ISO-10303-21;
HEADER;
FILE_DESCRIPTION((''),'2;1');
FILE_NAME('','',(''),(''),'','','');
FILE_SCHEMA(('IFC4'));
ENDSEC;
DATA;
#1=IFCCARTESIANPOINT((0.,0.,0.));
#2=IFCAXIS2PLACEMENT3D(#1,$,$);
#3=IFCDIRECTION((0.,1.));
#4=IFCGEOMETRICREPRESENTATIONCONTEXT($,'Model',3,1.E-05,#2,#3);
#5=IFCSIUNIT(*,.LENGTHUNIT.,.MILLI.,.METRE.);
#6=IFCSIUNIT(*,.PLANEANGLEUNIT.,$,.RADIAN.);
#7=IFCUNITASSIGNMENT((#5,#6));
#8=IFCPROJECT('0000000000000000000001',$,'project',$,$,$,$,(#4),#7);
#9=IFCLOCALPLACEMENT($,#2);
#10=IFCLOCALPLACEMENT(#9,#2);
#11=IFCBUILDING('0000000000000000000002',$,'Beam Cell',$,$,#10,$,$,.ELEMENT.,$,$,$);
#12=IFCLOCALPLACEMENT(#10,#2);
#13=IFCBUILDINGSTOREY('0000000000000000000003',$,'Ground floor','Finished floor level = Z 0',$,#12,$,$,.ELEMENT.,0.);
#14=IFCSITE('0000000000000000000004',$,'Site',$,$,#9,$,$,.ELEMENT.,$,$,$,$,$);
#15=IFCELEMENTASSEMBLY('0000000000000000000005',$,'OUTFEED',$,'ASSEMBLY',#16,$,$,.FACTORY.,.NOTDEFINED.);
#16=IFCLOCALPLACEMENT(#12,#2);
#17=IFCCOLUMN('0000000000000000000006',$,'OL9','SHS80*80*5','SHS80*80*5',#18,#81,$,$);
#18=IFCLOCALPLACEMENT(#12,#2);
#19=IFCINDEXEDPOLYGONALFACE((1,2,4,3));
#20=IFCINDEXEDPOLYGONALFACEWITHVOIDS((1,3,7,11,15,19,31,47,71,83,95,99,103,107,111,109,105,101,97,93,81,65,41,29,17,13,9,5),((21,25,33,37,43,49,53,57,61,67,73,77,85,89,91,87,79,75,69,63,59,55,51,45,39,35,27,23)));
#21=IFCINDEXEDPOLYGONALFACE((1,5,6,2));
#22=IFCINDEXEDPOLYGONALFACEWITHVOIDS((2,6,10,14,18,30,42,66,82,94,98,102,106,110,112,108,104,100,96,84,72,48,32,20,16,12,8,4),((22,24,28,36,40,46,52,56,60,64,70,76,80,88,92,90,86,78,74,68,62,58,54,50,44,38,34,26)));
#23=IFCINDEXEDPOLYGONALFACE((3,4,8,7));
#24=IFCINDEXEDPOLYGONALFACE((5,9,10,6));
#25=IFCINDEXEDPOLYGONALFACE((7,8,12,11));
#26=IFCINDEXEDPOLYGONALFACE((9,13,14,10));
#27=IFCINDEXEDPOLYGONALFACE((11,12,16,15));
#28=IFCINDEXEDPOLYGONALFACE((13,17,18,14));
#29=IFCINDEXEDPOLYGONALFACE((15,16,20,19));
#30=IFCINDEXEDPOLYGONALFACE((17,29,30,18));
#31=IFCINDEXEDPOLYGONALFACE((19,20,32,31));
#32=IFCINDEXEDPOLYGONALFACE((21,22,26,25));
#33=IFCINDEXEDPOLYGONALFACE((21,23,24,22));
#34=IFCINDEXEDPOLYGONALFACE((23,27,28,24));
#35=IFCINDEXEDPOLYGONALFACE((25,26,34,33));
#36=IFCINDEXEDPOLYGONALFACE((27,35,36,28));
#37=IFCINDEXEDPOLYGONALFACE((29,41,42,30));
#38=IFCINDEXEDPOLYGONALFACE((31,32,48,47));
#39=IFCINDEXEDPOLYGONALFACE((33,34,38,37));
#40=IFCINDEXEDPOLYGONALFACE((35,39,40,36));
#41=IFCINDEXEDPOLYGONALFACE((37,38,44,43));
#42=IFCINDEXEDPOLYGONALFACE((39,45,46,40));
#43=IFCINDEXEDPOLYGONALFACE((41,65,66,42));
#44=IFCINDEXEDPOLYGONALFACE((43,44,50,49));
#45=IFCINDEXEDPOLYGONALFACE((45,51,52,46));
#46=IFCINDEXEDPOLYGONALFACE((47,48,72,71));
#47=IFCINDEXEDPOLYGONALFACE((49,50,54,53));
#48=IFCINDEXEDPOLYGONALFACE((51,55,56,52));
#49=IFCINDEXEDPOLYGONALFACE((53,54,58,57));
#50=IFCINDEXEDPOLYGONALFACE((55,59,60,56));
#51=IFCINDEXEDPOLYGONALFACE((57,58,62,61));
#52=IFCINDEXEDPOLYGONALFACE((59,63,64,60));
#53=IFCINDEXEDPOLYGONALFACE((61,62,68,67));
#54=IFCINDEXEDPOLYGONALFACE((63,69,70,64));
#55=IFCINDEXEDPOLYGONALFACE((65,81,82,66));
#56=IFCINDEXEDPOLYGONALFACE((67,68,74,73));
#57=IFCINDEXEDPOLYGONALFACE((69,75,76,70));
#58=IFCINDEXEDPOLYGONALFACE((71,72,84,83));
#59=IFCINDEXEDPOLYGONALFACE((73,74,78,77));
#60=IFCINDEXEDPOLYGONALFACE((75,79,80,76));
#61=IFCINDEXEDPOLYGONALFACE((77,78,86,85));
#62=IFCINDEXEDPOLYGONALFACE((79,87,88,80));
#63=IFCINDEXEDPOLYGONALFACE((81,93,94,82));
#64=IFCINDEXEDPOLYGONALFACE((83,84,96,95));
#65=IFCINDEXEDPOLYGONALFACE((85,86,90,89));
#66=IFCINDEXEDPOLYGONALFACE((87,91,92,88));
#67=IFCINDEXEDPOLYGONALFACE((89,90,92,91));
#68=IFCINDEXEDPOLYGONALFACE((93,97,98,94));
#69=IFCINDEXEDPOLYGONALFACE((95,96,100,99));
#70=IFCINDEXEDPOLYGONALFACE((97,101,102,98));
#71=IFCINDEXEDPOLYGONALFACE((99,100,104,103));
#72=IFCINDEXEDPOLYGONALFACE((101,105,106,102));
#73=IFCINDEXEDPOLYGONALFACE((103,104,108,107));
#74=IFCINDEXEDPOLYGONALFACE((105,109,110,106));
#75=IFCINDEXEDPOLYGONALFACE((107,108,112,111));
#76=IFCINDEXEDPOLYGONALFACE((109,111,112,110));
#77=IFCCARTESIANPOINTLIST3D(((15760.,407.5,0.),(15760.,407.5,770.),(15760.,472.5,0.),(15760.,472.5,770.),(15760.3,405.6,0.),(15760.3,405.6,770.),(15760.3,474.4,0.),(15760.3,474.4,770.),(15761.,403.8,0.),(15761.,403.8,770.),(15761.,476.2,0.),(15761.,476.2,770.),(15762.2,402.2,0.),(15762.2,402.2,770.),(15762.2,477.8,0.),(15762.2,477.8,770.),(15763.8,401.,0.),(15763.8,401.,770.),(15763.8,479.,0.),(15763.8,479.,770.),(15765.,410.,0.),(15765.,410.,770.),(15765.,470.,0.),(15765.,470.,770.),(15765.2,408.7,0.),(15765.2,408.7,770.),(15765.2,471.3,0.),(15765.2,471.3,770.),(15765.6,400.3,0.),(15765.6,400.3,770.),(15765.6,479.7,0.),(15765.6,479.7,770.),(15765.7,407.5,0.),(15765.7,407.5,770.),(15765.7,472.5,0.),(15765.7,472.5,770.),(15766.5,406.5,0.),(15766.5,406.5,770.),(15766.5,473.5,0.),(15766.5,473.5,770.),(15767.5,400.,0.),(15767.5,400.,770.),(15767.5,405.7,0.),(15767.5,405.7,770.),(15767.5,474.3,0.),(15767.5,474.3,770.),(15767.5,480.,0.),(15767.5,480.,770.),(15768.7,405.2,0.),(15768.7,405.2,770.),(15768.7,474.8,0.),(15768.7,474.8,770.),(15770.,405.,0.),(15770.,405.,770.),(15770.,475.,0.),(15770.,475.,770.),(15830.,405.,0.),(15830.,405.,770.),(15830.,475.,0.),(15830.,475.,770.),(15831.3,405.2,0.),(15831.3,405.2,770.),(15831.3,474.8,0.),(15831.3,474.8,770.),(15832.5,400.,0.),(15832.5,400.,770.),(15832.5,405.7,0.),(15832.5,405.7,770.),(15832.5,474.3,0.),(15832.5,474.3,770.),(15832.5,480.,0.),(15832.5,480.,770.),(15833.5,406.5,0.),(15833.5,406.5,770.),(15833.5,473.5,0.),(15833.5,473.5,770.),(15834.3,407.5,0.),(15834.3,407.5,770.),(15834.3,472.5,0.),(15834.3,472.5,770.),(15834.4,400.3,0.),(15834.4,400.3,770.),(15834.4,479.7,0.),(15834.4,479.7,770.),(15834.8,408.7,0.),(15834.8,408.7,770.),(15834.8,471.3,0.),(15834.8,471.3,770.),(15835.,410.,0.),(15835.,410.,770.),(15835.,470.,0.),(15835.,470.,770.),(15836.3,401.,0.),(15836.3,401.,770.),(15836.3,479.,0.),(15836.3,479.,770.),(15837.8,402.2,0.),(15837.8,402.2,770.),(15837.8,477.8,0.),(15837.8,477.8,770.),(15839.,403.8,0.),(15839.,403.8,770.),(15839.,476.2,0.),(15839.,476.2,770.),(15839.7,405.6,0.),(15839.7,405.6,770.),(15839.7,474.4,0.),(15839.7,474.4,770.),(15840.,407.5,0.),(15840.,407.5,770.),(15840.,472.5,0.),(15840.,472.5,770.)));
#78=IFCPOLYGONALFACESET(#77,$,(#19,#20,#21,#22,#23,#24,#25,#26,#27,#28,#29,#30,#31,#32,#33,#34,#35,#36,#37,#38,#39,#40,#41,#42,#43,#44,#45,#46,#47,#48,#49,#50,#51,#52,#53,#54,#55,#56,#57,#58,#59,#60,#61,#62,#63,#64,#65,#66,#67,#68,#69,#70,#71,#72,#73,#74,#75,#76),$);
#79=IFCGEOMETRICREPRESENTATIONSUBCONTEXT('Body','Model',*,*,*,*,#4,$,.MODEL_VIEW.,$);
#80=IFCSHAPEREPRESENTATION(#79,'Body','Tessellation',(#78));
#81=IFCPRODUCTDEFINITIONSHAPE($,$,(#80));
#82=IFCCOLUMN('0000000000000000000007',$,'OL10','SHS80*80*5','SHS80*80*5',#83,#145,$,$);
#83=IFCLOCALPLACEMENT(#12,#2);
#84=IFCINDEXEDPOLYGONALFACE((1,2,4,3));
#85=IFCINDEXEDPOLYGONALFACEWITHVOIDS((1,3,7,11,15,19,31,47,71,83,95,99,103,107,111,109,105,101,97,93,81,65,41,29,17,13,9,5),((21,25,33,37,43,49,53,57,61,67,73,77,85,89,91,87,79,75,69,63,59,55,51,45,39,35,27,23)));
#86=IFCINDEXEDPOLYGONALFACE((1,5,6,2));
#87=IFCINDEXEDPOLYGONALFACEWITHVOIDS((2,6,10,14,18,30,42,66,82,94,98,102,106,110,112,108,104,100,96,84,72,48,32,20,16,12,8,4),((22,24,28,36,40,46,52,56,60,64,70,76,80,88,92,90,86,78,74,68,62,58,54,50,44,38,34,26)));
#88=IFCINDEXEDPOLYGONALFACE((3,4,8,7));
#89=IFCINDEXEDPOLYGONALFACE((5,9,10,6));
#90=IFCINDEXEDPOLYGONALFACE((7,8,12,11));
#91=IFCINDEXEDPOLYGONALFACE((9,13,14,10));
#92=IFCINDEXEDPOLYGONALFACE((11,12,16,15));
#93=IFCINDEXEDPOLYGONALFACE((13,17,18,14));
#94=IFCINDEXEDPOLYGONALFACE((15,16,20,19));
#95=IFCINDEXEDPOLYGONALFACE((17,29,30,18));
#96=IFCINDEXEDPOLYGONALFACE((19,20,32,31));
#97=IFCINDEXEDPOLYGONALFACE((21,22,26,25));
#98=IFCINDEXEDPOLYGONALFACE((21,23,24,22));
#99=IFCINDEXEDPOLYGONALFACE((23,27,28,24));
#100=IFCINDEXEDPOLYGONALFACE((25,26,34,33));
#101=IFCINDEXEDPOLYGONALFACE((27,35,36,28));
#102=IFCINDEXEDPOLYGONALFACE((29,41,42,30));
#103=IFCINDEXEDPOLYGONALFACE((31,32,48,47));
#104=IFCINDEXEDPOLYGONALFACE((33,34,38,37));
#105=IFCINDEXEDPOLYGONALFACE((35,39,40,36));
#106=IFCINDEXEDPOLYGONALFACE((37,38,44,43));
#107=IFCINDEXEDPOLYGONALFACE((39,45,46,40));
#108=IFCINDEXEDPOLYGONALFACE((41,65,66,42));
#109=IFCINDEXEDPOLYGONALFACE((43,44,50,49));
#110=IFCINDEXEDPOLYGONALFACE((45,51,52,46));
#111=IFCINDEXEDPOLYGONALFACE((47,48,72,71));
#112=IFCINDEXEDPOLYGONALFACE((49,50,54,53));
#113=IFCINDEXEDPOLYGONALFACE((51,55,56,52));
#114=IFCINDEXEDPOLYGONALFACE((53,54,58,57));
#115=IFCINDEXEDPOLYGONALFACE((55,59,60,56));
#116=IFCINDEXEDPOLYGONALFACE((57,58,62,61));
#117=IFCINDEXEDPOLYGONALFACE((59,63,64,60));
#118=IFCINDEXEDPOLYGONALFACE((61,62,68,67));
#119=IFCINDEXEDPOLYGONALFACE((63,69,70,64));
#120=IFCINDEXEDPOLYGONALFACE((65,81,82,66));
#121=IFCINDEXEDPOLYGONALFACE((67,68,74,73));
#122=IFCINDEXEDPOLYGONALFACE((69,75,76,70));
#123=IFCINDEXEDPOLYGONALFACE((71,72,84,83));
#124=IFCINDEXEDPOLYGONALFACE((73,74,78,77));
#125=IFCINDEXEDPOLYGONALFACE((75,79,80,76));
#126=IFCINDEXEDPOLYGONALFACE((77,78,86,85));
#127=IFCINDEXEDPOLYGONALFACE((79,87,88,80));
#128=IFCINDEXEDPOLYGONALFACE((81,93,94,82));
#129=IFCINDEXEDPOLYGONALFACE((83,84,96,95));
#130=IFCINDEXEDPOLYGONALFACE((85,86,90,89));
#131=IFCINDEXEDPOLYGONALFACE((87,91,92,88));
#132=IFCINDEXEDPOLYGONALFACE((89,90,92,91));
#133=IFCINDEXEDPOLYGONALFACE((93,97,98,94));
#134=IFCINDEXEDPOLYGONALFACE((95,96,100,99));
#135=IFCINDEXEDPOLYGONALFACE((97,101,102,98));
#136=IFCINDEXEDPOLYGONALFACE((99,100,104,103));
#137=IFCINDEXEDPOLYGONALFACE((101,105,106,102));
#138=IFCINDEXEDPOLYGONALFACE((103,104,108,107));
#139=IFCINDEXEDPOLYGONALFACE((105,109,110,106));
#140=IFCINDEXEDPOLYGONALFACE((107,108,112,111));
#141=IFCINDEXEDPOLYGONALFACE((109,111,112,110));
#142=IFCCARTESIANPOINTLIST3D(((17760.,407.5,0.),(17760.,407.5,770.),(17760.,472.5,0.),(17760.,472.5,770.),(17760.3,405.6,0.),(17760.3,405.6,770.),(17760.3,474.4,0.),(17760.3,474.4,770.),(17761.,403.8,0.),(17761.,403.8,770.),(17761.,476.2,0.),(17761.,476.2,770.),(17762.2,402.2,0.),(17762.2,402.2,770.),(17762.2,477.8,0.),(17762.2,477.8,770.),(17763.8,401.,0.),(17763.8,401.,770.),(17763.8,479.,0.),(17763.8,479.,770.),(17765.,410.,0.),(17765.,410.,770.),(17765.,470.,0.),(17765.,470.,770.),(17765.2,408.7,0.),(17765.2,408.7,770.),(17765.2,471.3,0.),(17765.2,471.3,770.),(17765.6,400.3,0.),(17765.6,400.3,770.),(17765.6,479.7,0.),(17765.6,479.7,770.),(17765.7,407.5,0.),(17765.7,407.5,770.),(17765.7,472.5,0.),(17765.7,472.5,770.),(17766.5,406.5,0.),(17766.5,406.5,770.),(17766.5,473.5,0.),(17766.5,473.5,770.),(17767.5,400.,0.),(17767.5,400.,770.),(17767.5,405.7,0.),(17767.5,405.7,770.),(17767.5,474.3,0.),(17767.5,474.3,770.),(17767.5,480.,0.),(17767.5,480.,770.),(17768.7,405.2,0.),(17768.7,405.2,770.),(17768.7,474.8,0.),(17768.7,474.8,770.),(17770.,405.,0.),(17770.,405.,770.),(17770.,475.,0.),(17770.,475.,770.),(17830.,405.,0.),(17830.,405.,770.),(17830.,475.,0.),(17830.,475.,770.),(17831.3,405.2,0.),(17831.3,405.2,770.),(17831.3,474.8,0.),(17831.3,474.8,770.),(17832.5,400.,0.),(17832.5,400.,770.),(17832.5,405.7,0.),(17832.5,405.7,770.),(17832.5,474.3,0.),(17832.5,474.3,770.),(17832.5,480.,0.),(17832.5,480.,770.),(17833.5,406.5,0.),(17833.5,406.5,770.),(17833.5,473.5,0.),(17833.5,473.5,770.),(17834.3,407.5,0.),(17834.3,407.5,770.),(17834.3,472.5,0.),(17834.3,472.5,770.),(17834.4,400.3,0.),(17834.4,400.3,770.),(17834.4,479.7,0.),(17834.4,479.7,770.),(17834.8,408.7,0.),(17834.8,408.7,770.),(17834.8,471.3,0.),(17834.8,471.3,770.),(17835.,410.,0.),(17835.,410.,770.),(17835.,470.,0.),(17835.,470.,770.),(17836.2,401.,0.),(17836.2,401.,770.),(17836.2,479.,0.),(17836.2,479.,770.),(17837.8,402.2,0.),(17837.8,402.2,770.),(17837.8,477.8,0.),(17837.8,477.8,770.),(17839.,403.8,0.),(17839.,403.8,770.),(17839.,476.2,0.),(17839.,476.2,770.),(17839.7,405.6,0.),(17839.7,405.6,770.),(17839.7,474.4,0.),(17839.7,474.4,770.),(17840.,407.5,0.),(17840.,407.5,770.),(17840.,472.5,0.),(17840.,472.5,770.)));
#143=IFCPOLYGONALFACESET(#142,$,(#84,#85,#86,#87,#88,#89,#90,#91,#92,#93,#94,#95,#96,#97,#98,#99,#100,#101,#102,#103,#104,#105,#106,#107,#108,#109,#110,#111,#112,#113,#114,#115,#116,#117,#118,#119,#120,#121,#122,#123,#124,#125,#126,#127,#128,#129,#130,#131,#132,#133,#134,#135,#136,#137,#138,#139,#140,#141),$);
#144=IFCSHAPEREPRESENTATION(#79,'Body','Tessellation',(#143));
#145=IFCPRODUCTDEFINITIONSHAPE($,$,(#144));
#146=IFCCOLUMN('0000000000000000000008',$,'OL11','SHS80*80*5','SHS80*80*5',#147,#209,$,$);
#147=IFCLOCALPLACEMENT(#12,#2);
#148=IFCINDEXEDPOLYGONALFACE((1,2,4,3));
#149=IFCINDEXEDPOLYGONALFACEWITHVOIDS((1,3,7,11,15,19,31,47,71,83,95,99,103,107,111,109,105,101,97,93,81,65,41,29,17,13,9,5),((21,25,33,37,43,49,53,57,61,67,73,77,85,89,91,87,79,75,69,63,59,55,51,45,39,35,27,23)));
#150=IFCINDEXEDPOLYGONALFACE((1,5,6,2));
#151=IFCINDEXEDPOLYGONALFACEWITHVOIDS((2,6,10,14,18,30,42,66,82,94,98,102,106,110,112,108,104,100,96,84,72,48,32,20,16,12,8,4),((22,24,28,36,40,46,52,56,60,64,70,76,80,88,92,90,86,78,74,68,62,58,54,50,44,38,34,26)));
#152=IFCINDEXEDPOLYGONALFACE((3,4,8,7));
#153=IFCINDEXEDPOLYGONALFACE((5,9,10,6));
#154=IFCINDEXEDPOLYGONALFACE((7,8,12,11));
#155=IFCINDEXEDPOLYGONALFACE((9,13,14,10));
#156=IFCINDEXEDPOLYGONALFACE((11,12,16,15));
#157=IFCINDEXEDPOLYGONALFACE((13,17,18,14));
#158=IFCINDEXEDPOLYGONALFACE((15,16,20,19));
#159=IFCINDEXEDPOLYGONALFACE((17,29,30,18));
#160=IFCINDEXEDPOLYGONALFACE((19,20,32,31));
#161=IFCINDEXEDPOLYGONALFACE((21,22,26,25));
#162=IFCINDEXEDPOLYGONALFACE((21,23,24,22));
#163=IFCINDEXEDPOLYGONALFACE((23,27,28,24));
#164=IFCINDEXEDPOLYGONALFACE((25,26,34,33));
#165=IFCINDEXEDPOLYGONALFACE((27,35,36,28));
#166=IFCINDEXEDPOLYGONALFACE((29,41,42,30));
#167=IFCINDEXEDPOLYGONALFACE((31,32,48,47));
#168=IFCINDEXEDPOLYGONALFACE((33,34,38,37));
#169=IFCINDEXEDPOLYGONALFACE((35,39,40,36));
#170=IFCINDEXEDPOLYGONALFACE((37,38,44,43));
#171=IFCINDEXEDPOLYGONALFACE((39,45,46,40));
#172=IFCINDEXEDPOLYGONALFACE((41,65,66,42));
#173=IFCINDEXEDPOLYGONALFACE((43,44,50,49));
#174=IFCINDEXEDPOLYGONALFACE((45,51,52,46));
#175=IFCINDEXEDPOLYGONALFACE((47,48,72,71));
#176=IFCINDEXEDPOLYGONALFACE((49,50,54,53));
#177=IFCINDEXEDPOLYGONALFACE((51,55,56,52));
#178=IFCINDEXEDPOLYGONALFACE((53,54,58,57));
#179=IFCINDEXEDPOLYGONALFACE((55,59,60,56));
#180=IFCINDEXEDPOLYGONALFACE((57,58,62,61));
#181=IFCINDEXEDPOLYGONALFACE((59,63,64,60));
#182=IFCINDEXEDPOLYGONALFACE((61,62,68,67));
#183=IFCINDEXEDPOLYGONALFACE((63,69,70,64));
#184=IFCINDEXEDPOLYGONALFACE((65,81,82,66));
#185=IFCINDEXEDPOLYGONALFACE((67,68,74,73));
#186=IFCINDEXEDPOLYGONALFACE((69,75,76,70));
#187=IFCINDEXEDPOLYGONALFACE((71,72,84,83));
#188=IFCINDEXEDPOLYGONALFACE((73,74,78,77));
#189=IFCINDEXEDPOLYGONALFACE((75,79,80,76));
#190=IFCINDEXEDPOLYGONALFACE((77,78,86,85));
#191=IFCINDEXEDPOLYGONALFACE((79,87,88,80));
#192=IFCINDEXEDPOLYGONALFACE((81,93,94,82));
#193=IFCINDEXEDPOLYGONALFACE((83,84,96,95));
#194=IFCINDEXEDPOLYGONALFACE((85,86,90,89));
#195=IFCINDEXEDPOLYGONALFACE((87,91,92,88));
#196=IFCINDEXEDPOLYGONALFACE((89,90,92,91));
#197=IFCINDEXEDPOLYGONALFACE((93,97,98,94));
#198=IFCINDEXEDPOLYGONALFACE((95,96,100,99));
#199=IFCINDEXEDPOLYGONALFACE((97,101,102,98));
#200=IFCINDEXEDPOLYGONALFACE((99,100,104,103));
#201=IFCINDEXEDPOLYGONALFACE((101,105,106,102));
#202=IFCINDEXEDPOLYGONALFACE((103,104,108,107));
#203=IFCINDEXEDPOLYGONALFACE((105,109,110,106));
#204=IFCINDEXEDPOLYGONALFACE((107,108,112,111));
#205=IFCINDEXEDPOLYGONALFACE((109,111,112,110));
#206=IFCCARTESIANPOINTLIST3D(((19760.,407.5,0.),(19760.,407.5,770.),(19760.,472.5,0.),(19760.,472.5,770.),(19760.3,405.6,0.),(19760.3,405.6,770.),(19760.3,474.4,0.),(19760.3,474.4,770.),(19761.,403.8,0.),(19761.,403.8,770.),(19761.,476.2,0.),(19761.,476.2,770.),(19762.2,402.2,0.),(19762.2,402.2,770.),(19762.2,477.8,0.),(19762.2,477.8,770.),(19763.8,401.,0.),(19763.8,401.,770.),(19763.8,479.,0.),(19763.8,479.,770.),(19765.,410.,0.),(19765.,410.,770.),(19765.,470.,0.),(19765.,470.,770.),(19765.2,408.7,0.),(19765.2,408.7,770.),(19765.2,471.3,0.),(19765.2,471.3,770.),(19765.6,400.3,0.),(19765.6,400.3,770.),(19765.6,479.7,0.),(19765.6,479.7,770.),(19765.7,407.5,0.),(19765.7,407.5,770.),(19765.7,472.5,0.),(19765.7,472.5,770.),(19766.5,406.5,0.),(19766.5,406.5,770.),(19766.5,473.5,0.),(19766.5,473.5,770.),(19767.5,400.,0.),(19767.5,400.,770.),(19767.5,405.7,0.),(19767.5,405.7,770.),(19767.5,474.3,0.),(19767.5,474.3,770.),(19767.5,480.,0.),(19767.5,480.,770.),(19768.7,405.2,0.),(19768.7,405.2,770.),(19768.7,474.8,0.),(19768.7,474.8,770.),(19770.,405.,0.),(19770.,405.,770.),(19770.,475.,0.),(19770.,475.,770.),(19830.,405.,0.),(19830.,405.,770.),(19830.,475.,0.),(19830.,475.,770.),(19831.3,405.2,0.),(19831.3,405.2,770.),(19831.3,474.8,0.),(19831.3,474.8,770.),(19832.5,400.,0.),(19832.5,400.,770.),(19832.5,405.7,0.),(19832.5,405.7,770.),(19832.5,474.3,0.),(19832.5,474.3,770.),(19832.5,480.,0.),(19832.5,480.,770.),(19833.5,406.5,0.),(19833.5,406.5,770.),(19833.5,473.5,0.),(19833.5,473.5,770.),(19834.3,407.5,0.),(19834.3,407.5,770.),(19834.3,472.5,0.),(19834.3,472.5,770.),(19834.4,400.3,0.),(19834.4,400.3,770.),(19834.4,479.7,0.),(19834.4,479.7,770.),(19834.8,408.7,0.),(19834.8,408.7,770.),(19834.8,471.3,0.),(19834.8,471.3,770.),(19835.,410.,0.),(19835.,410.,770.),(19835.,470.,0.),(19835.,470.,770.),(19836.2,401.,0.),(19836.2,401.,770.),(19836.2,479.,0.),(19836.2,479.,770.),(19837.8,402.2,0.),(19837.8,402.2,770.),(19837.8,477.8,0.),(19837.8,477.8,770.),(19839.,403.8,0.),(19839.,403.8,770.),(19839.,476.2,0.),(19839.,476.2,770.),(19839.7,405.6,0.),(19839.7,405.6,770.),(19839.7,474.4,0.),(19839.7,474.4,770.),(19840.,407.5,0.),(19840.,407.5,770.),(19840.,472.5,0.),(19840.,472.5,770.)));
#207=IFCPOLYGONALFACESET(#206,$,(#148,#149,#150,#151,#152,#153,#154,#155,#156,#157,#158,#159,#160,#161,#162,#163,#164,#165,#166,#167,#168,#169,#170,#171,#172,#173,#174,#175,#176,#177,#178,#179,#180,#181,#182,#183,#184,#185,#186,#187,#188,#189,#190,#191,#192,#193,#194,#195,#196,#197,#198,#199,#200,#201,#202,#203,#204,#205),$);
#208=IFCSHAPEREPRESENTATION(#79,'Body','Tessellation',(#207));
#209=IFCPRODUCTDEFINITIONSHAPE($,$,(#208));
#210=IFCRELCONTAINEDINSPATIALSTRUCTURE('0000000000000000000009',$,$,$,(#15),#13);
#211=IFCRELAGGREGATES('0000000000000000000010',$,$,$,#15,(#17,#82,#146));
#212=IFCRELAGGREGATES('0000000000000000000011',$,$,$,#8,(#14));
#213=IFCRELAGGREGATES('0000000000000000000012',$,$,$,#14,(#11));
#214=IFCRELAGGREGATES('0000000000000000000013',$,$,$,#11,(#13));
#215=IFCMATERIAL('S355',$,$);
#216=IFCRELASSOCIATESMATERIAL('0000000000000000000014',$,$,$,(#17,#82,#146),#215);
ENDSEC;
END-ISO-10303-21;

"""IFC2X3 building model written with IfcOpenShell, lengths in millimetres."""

from ifc_helpers import new_model, si_unit, direction, frame, origin, origin_2d, place, context, subcontext, project, spatial, hollow_rectangle, extrude, material, element, aggregate, save


model = new_model("IFC2X3")

# Units and contexts
model_context = context("Model", 3, precision=1e-05, world=origin(), true_north=direction((0.0, 1.0)))
body_context = subcontext(model_context, "Body", "Model", "MODEL_VIEW")
ifc_project = project(units=[si_unit("LENGTHUNIT", "METRE", prefix="MILLI"), si_unit("PLANEANGLEUNIT", "RADIAN")], contexts=[model_context])

# Site, building, storey
site_placement = place(None, origin())
site = spatial("IfcSite", under=ifc_project, at=site_placement, Name="Site", CompositionType="ELEMENT")
building_placement = place(site_placement, origin())
building = spatial("IfcBuilding", under=site, at=building_placement, Name="Beam Cell", CompositionType="ELEMENT")
storey_placement = place(building_placement, origin())
storey = spatial("IfcBuildingStorey", under=building, at=storey_placement, Name="Ground floor", Description="Finished floor level = Z 0", CompositionType="ELEMENT", Elevation=0.0)

# Element assembly, columns
ifc_material = material(Name="S355")
assembly_1_placement = place(storey_placement, origin())
assembly_1 = element("IfcElementAssembly", 1, at=assembly_1_placement, inside=storey, Name="OUTFEED", ObjectType="ASSEMBLY", AssemblyPlace="FACTORY", PredefinedType="NOTDEFINED")
column_1_placement = place(storey_placement, frame((15800.0, 440.0, 0.0), z_axis=(0.0, 0.0, 1.0), x_axis=(1.0, 0.0, 0.0)))
column_1 = element("IfcColumn", 2, at=column_1_placement, material=ifc_material, Name="OL9", Description="SHS80*80*5", ObjectType="SHS80*80*5", context=body_context, shape_type="SweptSolid", body=[
    extrude(hollow_rectangle(XDim=80.0, YDim=80.0, WallThickness=5.0, InnerFilletRadius=5.0, OuterFilletRadius=7.5, at=origin_2d()), origin(), (0.0, 0.0, 1.0), 770.0),
])
column_2_placement = place(storey_placement, frame((17800.0, 440.0, 0.0), z_axis=(0.0, 0.0, 1.0), x_axis=(1.0, 0.0, 0.0)))
column_2 = element("IfcColumn", 3, at=column_2_placement, material=ifc_material, Name="OL10", Description="SHS80*80*5", ObjectType="SHS80*80*5", context=body_context, shape_type="SweptSolid", body=[
    extrude(hollow_rectangle(XDim=80.0, YDim=80.0, WallThickness=5.0, InnerFilletRadius=5.0, OuterFilletRadius=7.5, at=origin_2d()), origin(), (0.0, 0.0, 1.0), 770.0),
])
column_3_placement = place(storey_placement, frame((19800.0, 440.0, 0.0), z_axis=(0.0, 0.0, 1.0), x_axis=(1.0, 0.0, 0.0)))
column_3 = element("IfcColumn", 4, at=column_3_placement, material=ifc_material, Name="OL11", Description="SHS80*80*5", ObjectType="SHS80*80*5", context=body_context, shape_type="SweptSolid", body=[
    extrude(hollow_rectangle(XDim=80.0, YDim=80.0, WallThickness=5.0, InnerFilletRadius=5.0, OuterFilletRadius=7.5, at=origin_2d()), origin(), (0.0, 0.0, 1.0), 770.0),
])
aggregate(assembly_1, [column_1, column_2, column_3])

save(model, "model.ifc")
